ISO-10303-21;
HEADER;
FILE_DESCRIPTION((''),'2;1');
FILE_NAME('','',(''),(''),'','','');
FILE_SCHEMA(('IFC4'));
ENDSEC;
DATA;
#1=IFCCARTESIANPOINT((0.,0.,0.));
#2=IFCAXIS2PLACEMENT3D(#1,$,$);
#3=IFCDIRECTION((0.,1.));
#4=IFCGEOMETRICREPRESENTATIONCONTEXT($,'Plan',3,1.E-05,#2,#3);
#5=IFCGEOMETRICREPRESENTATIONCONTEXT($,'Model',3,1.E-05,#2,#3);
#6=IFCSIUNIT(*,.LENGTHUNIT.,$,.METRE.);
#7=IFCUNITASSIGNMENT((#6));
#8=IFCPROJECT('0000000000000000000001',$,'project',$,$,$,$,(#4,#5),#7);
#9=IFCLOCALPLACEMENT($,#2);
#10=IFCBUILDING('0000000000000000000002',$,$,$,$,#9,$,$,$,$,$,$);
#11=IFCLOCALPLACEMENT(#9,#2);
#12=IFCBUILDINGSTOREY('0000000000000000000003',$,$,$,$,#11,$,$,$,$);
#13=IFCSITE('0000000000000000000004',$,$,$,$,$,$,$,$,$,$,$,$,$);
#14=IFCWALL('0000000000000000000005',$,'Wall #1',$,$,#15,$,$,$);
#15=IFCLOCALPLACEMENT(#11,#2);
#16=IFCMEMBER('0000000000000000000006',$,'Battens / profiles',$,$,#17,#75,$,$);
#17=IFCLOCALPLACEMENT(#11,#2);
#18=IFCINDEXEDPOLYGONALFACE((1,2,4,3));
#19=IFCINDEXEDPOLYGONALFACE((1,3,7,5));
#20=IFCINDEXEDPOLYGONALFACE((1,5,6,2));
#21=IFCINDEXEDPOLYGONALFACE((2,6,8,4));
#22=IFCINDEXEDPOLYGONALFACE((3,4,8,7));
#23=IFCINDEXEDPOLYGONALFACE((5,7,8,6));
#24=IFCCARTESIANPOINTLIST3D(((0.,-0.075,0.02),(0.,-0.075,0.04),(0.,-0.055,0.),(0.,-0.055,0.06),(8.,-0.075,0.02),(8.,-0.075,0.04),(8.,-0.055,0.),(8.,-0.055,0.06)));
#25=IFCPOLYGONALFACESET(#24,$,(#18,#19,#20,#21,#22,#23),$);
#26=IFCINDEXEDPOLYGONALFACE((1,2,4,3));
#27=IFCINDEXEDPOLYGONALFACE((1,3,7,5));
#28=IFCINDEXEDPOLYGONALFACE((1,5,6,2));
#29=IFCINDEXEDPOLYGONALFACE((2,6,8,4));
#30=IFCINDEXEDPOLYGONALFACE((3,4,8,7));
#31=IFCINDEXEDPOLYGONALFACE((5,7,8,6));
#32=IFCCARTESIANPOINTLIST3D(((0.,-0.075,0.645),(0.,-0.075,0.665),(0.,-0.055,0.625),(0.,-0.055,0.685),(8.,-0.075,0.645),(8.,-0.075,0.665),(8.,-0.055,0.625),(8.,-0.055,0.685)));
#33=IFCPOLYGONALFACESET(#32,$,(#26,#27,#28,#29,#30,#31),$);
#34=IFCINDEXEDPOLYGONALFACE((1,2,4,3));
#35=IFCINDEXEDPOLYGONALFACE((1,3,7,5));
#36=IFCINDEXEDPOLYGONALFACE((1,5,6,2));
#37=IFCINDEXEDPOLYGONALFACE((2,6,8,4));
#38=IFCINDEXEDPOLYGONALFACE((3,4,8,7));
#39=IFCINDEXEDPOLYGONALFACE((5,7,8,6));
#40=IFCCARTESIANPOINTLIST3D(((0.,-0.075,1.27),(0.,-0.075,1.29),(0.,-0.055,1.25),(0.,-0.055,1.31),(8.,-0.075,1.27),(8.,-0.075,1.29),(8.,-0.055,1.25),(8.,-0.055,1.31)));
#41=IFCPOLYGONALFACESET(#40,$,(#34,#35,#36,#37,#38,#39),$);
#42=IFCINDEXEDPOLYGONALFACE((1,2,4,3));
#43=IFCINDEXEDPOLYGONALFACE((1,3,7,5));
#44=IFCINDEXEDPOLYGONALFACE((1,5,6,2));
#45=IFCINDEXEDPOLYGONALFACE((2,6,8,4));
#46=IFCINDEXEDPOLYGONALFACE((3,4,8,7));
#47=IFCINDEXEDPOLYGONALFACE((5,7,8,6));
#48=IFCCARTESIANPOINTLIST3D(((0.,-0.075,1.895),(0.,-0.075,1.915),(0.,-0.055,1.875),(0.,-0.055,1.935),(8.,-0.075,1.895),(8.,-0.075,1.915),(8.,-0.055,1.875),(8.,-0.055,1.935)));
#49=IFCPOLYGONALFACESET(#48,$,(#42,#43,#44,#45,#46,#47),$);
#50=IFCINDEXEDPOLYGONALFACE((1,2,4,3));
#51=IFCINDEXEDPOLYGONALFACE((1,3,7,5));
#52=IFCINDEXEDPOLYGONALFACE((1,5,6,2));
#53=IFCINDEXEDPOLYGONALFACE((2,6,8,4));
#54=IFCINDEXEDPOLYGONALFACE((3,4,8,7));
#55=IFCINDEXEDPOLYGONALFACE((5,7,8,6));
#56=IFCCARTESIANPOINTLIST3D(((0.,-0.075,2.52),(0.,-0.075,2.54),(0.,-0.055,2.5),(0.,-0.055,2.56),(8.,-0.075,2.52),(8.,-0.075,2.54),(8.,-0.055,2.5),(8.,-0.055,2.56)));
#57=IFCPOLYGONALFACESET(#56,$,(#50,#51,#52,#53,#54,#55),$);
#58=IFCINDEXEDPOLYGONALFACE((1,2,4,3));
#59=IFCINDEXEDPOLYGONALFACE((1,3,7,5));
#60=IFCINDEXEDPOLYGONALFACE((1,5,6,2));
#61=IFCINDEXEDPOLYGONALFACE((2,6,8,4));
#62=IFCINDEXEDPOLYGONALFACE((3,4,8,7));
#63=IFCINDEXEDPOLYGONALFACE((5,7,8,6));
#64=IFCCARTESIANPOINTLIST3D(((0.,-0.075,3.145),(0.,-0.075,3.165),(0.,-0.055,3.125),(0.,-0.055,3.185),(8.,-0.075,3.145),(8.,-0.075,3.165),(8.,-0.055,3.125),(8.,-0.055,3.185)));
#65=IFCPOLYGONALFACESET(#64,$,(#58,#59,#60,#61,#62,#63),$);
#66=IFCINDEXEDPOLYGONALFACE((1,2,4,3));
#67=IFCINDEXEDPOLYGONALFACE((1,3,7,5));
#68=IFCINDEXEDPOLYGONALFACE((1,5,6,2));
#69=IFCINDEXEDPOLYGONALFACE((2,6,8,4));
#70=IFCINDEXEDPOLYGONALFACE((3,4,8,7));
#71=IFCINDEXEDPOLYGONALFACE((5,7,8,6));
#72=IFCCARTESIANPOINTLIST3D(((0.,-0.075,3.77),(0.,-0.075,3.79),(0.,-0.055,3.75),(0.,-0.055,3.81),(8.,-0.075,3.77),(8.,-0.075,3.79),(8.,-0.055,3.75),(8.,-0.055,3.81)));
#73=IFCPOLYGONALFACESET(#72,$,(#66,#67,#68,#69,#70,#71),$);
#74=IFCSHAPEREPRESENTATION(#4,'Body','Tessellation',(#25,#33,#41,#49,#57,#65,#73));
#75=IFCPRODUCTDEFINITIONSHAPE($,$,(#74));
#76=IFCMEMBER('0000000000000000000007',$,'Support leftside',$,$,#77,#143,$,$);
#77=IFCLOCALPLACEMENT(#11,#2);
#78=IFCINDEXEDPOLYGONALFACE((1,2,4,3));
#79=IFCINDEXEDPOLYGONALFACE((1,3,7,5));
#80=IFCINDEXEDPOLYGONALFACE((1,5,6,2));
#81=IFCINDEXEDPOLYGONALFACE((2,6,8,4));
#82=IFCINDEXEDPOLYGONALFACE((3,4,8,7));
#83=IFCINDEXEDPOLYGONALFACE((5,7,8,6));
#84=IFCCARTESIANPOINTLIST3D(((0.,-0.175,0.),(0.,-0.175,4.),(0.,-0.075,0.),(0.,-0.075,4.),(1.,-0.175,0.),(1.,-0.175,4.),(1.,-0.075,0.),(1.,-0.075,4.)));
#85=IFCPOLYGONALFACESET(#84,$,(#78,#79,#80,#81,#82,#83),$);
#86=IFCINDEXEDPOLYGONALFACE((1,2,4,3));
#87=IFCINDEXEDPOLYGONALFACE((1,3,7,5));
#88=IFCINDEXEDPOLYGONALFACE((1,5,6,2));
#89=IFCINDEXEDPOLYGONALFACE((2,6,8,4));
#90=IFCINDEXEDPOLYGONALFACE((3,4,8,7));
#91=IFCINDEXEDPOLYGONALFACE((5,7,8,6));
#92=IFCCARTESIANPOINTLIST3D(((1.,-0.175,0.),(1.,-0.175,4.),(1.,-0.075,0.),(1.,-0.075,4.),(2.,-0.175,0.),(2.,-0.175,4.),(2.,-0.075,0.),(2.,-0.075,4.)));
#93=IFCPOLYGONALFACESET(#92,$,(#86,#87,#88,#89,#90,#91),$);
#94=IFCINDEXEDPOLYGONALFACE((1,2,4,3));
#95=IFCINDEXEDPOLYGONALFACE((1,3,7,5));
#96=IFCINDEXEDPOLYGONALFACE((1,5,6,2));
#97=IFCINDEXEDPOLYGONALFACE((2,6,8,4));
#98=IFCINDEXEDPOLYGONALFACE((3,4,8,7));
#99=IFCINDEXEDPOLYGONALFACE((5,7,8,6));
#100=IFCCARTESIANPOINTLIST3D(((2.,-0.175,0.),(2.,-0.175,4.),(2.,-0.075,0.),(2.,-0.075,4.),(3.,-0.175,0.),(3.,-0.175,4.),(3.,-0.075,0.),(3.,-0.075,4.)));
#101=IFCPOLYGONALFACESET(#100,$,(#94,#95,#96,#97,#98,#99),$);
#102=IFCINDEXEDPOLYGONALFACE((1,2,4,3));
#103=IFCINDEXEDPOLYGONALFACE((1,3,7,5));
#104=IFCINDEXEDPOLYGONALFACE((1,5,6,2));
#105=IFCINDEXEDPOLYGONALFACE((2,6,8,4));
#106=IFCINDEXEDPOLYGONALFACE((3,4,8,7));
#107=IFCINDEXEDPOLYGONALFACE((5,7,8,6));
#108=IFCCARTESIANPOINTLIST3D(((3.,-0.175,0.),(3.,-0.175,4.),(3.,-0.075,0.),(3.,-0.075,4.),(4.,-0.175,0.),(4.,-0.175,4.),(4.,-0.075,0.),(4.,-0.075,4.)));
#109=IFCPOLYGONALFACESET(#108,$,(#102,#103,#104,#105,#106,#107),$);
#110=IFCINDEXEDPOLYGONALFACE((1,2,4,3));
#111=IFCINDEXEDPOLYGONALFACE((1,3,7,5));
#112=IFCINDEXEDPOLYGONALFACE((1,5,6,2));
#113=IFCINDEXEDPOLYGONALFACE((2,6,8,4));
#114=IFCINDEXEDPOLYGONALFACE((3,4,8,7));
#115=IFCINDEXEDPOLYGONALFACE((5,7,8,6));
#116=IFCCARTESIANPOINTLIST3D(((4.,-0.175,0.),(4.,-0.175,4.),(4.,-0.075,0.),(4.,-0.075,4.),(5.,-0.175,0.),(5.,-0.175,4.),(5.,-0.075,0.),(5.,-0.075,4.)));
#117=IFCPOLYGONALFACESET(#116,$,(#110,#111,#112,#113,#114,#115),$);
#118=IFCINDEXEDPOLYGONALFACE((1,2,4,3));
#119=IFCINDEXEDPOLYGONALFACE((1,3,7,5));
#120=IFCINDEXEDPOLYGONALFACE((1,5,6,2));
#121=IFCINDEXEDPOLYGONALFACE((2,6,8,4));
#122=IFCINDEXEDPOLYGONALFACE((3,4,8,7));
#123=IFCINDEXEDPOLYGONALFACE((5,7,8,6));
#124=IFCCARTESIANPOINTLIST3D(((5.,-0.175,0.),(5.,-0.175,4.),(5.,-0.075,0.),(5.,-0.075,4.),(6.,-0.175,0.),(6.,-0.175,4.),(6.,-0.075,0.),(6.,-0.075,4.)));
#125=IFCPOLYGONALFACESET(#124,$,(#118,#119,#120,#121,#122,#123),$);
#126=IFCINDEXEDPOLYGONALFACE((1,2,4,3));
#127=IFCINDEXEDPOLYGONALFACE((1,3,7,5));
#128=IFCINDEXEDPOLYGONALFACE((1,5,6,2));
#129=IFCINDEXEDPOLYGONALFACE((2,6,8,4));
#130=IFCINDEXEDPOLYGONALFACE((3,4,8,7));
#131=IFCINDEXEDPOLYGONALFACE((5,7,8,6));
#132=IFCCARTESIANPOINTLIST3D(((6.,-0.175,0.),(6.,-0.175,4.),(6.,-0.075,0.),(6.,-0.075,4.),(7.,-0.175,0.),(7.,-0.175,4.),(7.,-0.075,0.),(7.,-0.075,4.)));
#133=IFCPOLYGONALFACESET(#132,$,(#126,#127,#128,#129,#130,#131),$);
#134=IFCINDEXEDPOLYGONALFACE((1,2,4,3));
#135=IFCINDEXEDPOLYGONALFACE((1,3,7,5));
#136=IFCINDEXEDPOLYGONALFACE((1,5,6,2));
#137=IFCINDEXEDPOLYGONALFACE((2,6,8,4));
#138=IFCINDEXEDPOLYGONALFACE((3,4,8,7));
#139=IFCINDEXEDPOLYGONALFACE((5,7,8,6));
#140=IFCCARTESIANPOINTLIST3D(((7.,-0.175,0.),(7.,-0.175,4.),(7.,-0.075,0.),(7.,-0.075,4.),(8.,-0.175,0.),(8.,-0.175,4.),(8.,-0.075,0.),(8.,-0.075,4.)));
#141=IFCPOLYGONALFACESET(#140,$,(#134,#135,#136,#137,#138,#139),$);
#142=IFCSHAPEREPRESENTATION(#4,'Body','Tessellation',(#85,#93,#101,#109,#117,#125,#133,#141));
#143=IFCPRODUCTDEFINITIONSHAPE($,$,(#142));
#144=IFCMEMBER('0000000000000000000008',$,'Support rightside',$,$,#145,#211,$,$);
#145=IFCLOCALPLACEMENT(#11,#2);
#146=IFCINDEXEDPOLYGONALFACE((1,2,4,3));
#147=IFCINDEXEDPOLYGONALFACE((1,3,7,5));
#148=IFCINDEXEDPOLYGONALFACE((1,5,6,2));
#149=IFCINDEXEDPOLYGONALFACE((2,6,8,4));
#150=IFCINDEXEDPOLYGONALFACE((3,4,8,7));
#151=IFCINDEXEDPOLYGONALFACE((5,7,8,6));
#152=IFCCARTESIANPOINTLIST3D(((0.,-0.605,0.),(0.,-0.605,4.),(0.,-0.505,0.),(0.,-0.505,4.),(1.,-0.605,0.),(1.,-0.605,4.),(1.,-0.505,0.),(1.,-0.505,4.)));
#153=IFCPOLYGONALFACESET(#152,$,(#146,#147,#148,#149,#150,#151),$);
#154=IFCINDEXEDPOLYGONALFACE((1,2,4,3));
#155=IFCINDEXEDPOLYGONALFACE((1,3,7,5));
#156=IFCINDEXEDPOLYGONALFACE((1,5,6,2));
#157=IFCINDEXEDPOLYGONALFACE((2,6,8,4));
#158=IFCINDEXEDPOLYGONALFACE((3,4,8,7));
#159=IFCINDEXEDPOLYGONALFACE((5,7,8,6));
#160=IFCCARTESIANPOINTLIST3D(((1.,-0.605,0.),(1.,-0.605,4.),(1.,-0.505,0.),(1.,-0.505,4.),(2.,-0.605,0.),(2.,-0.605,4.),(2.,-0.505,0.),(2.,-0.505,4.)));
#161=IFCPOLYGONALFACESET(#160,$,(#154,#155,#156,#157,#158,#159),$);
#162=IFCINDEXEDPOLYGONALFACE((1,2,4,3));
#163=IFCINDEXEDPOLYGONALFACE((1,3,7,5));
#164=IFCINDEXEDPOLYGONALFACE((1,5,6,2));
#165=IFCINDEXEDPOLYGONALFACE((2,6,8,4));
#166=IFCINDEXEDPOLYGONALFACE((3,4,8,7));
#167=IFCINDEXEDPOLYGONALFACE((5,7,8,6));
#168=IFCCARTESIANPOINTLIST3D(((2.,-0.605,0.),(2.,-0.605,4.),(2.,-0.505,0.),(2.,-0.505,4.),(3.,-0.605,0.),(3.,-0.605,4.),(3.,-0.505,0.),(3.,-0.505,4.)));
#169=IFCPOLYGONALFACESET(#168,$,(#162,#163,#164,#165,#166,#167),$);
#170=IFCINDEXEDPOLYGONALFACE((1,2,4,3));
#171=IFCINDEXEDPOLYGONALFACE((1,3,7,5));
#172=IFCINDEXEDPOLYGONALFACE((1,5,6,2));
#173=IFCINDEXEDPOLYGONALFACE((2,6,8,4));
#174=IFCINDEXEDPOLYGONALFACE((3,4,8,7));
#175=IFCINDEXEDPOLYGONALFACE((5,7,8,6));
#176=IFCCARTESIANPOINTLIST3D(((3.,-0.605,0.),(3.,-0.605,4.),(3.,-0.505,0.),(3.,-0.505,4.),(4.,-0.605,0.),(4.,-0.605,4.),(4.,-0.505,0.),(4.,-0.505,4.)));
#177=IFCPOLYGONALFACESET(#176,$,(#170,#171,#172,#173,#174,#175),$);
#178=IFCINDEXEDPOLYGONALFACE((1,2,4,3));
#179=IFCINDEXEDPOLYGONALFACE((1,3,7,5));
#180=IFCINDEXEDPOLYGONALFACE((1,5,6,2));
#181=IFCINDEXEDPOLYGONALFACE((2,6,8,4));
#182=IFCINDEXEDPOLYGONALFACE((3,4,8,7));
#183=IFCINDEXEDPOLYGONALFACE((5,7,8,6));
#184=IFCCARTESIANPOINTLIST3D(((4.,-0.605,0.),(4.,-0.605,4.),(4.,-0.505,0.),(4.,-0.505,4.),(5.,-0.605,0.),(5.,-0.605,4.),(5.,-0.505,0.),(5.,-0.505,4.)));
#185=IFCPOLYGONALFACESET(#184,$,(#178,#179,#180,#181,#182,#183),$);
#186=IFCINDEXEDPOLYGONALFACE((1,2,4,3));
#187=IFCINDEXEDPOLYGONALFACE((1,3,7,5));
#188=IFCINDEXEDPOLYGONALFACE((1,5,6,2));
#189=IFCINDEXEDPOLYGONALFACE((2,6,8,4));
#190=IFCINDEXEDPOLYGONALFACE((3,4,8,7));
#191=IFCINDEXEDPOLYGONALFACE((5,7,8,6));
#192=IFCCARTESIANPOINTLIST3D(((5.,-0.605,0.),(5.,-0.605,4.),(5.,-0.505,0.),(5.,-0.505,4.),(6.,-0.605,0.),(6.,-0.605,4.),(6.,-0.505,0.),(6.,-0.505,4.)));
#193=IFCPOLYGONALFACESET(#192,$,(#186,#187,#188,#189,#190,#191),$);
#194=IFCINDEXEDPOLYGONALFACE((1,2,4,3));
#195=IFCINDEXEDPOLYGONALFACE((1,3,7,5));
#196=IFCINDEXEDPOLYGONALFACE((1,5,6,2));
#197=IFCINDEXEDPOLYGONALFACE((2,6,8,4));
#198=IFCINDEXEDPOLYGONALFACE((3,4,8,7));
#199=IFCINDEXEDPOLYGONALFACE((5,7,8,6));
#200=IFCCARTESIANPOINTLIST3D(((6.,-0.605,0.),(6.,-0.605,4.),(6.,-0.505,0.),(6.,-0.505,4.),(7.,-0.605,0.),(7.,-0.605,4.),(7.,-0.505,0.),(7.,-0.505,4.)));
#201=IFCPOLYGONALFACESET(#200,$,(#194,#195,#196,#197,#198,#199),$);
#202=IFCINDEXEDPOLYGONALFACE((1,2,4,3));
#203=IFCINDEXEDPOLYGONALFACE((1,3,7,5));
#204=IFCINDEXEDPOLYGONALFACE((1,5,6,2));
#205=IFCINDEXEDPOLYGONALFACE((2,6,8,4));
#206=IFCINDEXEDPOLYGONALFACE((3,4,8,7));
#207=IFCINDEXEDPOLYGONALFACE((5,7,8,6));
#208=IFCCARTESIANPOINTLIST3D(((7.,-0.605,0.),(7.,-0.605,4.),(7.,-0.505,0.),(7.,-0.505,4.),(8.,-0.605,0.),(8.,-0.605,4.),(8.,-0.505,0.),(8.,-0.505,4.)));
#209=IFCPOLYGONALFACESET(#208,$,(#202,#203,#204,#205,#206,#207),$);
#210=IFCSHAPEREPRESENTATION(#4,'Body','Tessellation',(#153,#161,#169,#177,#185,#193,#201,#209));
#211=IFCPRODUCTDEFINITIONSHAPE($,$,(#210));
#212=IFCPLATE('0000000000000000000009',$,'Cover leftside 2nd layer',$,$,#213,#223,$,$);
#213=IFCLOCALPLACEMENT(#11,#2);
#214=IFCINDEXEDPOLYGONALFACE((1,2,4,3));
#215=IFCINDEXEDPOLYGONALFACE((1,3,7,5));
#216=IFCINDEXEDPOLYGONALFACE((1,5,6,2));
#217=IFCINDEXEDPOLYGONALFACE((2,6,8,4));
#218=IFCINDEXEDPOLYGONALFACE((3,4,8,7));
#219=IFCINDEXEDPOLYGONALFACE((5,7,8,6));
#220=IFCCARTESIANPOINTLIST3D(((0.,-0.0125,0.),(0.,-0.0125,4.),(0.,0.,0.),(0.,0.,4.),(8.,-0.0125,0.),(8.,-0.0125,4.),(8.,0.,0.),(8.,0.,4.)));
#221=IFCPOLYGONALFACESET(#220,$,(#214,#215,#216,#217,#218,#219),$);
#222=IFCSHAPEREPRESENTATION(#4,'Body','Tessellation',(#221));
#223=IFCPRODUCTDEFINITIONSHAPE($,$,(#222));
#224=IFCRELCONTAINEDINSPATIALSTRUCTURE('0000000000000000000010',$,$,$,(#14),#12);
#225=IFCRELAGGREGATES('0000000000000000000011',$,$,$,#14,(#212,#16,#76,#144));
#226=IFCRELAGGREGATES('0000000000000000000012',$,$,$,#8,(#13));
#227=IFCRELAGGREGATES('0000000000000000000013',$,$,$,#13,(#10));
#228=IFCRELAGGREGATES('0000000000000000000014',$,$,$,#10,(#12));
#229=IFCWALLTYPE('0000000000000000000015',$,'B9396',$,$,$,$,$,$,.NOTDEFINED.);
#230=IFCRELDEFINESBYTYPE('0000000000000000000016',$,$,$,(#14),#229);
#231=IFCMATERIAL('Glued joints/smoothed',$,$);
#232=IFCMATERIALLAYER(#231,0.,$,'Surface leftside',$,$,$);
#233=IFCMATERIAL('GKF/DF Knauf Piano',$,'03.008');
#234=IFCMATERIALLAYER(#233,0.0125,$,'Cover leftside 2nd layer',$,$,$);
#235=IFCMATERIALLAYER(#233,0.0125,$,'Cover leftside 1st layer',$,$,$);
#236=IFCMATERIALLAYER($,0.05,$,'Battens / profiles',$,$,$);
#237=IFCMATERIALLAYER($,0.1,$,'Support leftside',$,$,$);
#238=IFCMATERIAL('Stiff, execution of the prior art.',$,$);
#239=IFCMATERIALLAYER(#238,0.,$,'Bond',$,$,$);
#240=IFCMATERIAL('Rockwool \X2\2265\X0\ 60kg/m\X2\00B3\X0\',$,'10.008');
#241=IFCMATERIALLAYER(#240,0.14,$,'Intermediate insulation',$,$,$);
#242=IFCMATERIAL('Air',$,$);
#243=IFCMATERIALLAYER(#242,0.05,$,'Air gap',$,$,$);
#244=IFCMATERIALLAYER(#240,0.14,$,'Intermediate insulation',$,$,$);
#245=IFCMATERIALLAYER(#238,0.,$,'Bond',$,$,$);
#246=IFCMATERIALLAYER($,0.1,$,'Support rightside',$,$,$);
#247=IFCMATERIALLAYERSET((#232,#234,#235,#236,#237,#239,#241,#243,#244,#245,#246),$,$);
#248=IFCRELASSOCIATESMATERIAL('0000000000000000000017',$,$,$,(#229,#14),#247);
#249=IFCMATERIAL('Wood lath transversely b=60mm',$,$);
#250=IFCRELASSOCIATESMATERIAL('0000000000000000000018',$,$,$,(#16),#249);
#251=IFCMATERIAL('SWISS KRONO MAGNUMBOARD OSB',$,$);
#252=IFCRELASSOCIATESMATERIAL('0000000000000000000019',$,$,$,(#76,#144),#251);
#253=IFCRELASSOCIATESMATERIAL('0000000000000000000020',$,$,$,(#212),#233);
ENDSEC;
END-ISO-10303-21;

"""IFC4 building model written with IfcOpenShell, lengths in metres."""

from ifc_helpers import new_model, si_unit, direction, frame, frame_2d, origin, origin_with_axes, place, context, project, spatial, polyline, rectangle, outline, extrude, material, layer, layer_set, type_object, element, aggregate, save


model = new_model("IFC4")

# Units and contexts
plan_context = context("Plan", 3, precision=1e-05, world=origin(), true_north=direction((0.0, 1.0)))
model_context = context("Model", 3, precision=1e-05, world=origin(), true_north=direction((0.0, 1.0)))
ifc_project = project(units=[si_unit("LENGTHUNIT", "METRE")], contexts=[plan_context, model_context])

# Site, building, storey
site = spatial("IfcSite", under=ifc_project)
building_placement = place(None, origin())
building = spatial("IfcBuilding", under=site, at=building_placement)
storey_placement = place(building_placement, origin())
storey = spatial("IfcBuildingStorey", under=building, at=storey_placement)

# Wall, members, plate
ifc_material_1 = material(Name="Glued joints/smoothed")
ifc_layer_1 = layer(ifc_material_1, 0.0, Name="Surface leftside")
ifc_material_2 = material(Name="GKF/DF Knauf Piano", Category="03.008")
ifc_layer_2 = layer(ifc_material_2, 0.0125, Name="Cover leftside 2nd layer")
ifc_layer_3 = layer(ifc_material_2, 0.0125, Name="Cover leftside 1st layer")
ifc_layer_4 = layer(None, 0.05, Name="Battens / profiles")
ifc_layer_5 = layer(None, 0.1, Name="Support leftside")
ifc_material_3 = material(Name="Stiff, execution of the prior art.")
ifc_layer_6 = layer(ifc_material_3, 0.0, Name="Bond")
ifc_material_4 = material(Name="Rockwool ≥ 60kg/m³", Category="10.008")
ifc_layer_7 = layer(ifc_material_4, 0.14, Name="Intermediate insulation")
ifc_material_5 = material(Name="Air")
ifc_layer_8 = layer(ifc_material_5, 0.05, Name="Air gap")
ifc_layer_9 = layer(ifc_material_4, 0.14, Name="Intermediate insulation")
ifc_layer_10 = layer(ifc_material_3, 0.0, Name="Bond")
ifc_layer_11 = layer(None, 0.1, Name="Support rightside")
ifc_layer_set = layer_set([ifc_layer_1, ifc_layer_2, ifc_layer_3, ifc_layer_4, ifc_layer_5, ifc_layer_6, ifc_layer_7, ifc_layer_8, ifc_layer_9, ifc_layer_10, ifc_layer_11])
wall_type = type_object("IfcWallType", Name="B9396", PredefinedType="NOTDEFINED", material=ifc_layer_set)
wall_placement = place(None, frame((0.0, 0.0, 0.0), z_axis=(0.0, -1.0, 0.0), x_axis=(1.0, 0.0, 0.0)))
wall = element("IfcWall", 1, at=wall_placement, inside=storey, type_object=wall_type, material=ifc_layer_set, Name="Wall #1")
ifc_material_6 = material(Name="Wood lath transversely b=60mm")
member_1_placement = place(wall_placement, origin())
member_1 = element("IfcMember", 2, at=member_1_placement, material=ifc_material_6, Name="Battens / profiles", context=plan_context, shape_type="SweptSolid", body=[
    extrude(outline(polyline([(0.0, 0.0), (0.06, 0.0), (0.04, 0.02), (0.02, 0.02), (0.0, 0.0)])), frame((0.0, 0.0, 0.055), z_axis=(1.0, 0.0, 0.0), x_axis=(0.0, 1.0, 0.0)), (0.0, 0.0, 1.0), 8.0),
    extrude(outline(polyline([(0.0, 0.0), (0.06, 0.0), (0.04, 0.02), (0.02, 0.02), (0.0, 0.0)])), frame((0.0, 0.625, 0.055), z_axis=(1.0, 0.0, 0.0), x_axis=(0.0, 1.0, 0.0)), (0.0, 0.0, 1.0), 8.0),
    extrude(outline(polyline([(0.0, 0.0), (0.06, 0.0), (0.04, 0.02), (0.02, 0.02), (0.0, 0.0)])), frame((0.0, 1.25, 0.055), z_axis=(1.0, 0.0, 0.0), x_axis=(0.0, 1.0, 0.0)), (0.0, 0.0, 1.0), 8.0),
    extrude(outline(polyline([(0.0, 0.0), (0.06, 0.0), (0.04, 0.02), (0.02, 0.02), (0.0, 0.0)])), frame((0.0, 1.875, 0.055), z_axis=(1.0, 0.0, 0.0), x_axis=(0.0, 1.0, 0.0)), (0.0, 0.0, 1.0), 8.0),
    extrude(outline(polyline([(0.0, 0.0), (0.06, 0.0), (0.04, 0.02), (0.02, 0.02), (0.0, 0.0)])), frame((0.0, 2.5, 0.055), z_axis=(1.0, 0.0, 0.0), x_axis=(0.0, 1.0, 0.0)), (0.0, 0.0, 1.0), 8.0),
    extrude(outline(polyline([(0.0, 0.0), (0.06, 0.0), (0.04, 0.02), (0.02, 0.02), (0.0, 0.0)])), frame((0.0, 3.125, 0.055), z_axis=(1.0, 0.0, 0.0), x_axis=(0.0, 1.0, 0.0)), (0.0, 0.0, 1.0), 8.0),
    extrude(outline(polyline([(0.0, 0.0), (0.06, 0.0), (0.04, 0.02), (0.02, 0.02), (0.0, 0.0)])), frame((0.0, 3.75, 0.055), z_axis=(1.0, 0.0, 0.0), x_axis=(0.0, 1.0, 0.0)), (0.0, 0.0, 1.0), 8.0),
])
ifc_material_7 = material(Name="SWISS KRONO MAGNUMBOARD OSB")
member_2_placement = place(wall_placement, origin())
member_2 = element("IfcMember", 3, at=member_2_placement, material=ifc_material_7, Name="Support leftside", context=plan_context, shape_type="SweptSolid", body=[
    extrude(rectangle(XDim=1.0, YDim=0.1, at=frame_2d((0.5, 0.05), x_axis=(1.0, 0.0))), frame((0.0, 4.0, 0.075), z_axis=(0.0, -1.0, 0.0), x_axis=(1.0, 0.0, 0.0)), (0.0, 0.0, 1.0), 4.0),
    extrude(rectangle(XDim=1.0, YDim=0.1, at=frame_2d((0.5, 0.05), x_axis=(1.0, 0.0))), frame((1.0, 4.0, 0.075), z_axis=(0.0, -1.0, 0.0), x_axis=(1.0, 0.0, 0.0)), (0.0, 0.0, 1.0), 4.0),
    extrude(rectangle(XDim=1.0, YDim=0.1, at=frame_2d((0.5, 0.05), x_axis=(1.0, 0.0))), frame((2.0, 4.0, 0.075), z_axis=(0.0, -1.0, 0.0), x_axis=(1.0, 0.0, 0.0)), (0.0, 0.0, 1.0), 4.0),
    extrude(rectangle(XDim=1.0, YDim=0.1, at=frame_2d((0.5, 0.05), x_axis=(1.0, 0.0))), frame((3.0, 4.0, 0.075), z_axis=(0.0, -1.0, 0.0), x_axis=(1.0, 0.0, 0.0)), (0.0, 0.0, 1.0), 4.0),
    extrude(rectangle(XDim=1.0, YDim=0.1, at=frame_2d((0.5, 0.05), x_axis=(1.0, 0.0))), frame((4.0, 4.0, 0.075), z_axis=(0.0, -1.0, 0.0), x_axis=(1.0, 0.0, 0.0)), (0.0, 0.0, 1.0), 4.0),
    extrude(rectangle(XDim=1.0, YDim=0.1, at=frame_2d((0.5, 0.05), x_axis=(1.0, 0.0))), frame((5.0, 4.0, 0.075), z_axis=(0.0, -1.0, 0.0), x_axis=(1.0, 0.0, 0.0)), (0.0, 0.0, 1.0), 4.0),
    extrude(rectangle(XDim=1.0, YDim=0.1, at=frame_2d((0.5, 0.05), x_axis=(1.0, 0.0))), frame((6.0, 4.0, 0.075), z_axis=(0.0, -1.0, 0.0), x_axis=(1.0, 0.0, 0.0)), (0.0, 0.0, 1.0), 4.0),
    extrude(rectangle(XDim=1.0, YDim=0.1, at=frame_2d((0.5, 0.05), x_axis=(1.0, 0.0))), frame((7.0, 4.0, 0.075), z_axis=(0.0, -1.0, 0.0), x_axis=(1.0, 0.0, 0.0)), (0.0, 0.0, 1.0), 4.0),
])
member_3_placement = place(wall_placement, origin())
member_3 = element("IfcMember", 4, at=member_3_placement, material=ifc_material_7, Name="Support rightside", context=plan_context, shape_type="SweptSolid", body=[
    extrude(rectangle(XDim=1.0, YDim=0.1, at=frame_2d((0.5, 0.05), x_axis=(1.0, 0.0))), frame((0.0, 4.0, 0.505), z_axis=(0.0, -1.0, 0.0), x_axis=(1.0, 0.0, 0.0)), (0.0, 0.0, 1.0), 4.0),
    extrude(rectangle(XDim=1.0, YDim=0.1, at=frame_2d((0.5, 0.05), x_axis=(1.0, 0.0))), frame((1.0, 4.0, 0.505), z_axis=(0.0, -1.0, 0.0), x_axis=(1.0, 0.0, 0.0)), (0.0, 0.0, 1.0), 4.0),
    extrude(rectangle(XDim=1.0, YDim=0.1, at=frame_2d((0.5, 0.05), x_axis=(1.0, 0.0))), frame((2.0, 4.0, 0.505), z_axis=(0.0, -1.0, 0.0), x_axis=(1.0, 0.0, 0.0)), (0.0, 0.0, 1.0), 4.0),
    extrude(rectangle(XDim=1.0, YDim=0.1, at=frame_2d((0.5, 0.05), x_axis=(1.0, 0.0))), frame((3.0, 4.0, 0.505), z_axis=(0.0, -1.0, 0.0), x_axis=(1.0, 0.0, 0.0)), (0.0, 0.0, 1.0), 4.0),
    extrude(rectangle(XDim=1.0, YDim=0.1, at=frame_2d((0.5, 0.05), x_axis=(1.0, 0.0))), frame((4.0, 4.0, 0.505), z_axis=(0.0, -1.0, 0.0), x_axis=(1.0, 0.0, 0.0)), (0.0, 0.0, 1.0), 4.0),
    extrude(rectangle(XDim=1.0, YDim=0.1, at=frame_2d((0.5, 0.05), x_axis=(1.0, 0.0))), frame((5.0, 4.0, 0.505), z_axis=(0.0, -1.0, 0.0), x_axis=(1.0, 0.0, 0.0)), (0.0, 0.0, 1.0), 4.0),
    extrude(rectangle(XDim=1.0, YDim=0.1, at=frame_2d((0.5, 0.05), x_axis=(1.0, 0.0))), frame((6.0, 4.0, 0.505), z_axis=(0.0, -1.0, 0.0), x_axis=(1.0, 0.0, 0.0)), (0.0, 0.0, 1.0), 4.0),
    extrude(rectangle(XDim=1.0, YDim=0.1, at=frame_2d((0.5, 0.05), x_axis=(1.0, 0.0))), frame((7.0, 4.0, 0.505), z_axis=(0.0, -1.0, 0.0), x_axis=(1.0, 0.0, 0.0)), (0.0, 0.0, 1.0), 4.0),
])
plate_1_placement = place(wall_placement, origin())
plate_1 = element("IfcPlate", 5, at=plate_1_placement, material=ifc_material_2, Name="Cover leftside 2nd layer", context=plan_context, shape_type="SweptSolid", body=[
    extrude(rectangle(XDim=8.0, YDim=4.0, at=frame_2d((4.0, 2.0), x_axis=(1.0, 0.0))), origin_with_axes(), (0.0, 0.0, 1.0), 0.0125),
])
aggregate(wall, [plate_1, member_1, member_2, member_3])

save(model, "model.ifc")
